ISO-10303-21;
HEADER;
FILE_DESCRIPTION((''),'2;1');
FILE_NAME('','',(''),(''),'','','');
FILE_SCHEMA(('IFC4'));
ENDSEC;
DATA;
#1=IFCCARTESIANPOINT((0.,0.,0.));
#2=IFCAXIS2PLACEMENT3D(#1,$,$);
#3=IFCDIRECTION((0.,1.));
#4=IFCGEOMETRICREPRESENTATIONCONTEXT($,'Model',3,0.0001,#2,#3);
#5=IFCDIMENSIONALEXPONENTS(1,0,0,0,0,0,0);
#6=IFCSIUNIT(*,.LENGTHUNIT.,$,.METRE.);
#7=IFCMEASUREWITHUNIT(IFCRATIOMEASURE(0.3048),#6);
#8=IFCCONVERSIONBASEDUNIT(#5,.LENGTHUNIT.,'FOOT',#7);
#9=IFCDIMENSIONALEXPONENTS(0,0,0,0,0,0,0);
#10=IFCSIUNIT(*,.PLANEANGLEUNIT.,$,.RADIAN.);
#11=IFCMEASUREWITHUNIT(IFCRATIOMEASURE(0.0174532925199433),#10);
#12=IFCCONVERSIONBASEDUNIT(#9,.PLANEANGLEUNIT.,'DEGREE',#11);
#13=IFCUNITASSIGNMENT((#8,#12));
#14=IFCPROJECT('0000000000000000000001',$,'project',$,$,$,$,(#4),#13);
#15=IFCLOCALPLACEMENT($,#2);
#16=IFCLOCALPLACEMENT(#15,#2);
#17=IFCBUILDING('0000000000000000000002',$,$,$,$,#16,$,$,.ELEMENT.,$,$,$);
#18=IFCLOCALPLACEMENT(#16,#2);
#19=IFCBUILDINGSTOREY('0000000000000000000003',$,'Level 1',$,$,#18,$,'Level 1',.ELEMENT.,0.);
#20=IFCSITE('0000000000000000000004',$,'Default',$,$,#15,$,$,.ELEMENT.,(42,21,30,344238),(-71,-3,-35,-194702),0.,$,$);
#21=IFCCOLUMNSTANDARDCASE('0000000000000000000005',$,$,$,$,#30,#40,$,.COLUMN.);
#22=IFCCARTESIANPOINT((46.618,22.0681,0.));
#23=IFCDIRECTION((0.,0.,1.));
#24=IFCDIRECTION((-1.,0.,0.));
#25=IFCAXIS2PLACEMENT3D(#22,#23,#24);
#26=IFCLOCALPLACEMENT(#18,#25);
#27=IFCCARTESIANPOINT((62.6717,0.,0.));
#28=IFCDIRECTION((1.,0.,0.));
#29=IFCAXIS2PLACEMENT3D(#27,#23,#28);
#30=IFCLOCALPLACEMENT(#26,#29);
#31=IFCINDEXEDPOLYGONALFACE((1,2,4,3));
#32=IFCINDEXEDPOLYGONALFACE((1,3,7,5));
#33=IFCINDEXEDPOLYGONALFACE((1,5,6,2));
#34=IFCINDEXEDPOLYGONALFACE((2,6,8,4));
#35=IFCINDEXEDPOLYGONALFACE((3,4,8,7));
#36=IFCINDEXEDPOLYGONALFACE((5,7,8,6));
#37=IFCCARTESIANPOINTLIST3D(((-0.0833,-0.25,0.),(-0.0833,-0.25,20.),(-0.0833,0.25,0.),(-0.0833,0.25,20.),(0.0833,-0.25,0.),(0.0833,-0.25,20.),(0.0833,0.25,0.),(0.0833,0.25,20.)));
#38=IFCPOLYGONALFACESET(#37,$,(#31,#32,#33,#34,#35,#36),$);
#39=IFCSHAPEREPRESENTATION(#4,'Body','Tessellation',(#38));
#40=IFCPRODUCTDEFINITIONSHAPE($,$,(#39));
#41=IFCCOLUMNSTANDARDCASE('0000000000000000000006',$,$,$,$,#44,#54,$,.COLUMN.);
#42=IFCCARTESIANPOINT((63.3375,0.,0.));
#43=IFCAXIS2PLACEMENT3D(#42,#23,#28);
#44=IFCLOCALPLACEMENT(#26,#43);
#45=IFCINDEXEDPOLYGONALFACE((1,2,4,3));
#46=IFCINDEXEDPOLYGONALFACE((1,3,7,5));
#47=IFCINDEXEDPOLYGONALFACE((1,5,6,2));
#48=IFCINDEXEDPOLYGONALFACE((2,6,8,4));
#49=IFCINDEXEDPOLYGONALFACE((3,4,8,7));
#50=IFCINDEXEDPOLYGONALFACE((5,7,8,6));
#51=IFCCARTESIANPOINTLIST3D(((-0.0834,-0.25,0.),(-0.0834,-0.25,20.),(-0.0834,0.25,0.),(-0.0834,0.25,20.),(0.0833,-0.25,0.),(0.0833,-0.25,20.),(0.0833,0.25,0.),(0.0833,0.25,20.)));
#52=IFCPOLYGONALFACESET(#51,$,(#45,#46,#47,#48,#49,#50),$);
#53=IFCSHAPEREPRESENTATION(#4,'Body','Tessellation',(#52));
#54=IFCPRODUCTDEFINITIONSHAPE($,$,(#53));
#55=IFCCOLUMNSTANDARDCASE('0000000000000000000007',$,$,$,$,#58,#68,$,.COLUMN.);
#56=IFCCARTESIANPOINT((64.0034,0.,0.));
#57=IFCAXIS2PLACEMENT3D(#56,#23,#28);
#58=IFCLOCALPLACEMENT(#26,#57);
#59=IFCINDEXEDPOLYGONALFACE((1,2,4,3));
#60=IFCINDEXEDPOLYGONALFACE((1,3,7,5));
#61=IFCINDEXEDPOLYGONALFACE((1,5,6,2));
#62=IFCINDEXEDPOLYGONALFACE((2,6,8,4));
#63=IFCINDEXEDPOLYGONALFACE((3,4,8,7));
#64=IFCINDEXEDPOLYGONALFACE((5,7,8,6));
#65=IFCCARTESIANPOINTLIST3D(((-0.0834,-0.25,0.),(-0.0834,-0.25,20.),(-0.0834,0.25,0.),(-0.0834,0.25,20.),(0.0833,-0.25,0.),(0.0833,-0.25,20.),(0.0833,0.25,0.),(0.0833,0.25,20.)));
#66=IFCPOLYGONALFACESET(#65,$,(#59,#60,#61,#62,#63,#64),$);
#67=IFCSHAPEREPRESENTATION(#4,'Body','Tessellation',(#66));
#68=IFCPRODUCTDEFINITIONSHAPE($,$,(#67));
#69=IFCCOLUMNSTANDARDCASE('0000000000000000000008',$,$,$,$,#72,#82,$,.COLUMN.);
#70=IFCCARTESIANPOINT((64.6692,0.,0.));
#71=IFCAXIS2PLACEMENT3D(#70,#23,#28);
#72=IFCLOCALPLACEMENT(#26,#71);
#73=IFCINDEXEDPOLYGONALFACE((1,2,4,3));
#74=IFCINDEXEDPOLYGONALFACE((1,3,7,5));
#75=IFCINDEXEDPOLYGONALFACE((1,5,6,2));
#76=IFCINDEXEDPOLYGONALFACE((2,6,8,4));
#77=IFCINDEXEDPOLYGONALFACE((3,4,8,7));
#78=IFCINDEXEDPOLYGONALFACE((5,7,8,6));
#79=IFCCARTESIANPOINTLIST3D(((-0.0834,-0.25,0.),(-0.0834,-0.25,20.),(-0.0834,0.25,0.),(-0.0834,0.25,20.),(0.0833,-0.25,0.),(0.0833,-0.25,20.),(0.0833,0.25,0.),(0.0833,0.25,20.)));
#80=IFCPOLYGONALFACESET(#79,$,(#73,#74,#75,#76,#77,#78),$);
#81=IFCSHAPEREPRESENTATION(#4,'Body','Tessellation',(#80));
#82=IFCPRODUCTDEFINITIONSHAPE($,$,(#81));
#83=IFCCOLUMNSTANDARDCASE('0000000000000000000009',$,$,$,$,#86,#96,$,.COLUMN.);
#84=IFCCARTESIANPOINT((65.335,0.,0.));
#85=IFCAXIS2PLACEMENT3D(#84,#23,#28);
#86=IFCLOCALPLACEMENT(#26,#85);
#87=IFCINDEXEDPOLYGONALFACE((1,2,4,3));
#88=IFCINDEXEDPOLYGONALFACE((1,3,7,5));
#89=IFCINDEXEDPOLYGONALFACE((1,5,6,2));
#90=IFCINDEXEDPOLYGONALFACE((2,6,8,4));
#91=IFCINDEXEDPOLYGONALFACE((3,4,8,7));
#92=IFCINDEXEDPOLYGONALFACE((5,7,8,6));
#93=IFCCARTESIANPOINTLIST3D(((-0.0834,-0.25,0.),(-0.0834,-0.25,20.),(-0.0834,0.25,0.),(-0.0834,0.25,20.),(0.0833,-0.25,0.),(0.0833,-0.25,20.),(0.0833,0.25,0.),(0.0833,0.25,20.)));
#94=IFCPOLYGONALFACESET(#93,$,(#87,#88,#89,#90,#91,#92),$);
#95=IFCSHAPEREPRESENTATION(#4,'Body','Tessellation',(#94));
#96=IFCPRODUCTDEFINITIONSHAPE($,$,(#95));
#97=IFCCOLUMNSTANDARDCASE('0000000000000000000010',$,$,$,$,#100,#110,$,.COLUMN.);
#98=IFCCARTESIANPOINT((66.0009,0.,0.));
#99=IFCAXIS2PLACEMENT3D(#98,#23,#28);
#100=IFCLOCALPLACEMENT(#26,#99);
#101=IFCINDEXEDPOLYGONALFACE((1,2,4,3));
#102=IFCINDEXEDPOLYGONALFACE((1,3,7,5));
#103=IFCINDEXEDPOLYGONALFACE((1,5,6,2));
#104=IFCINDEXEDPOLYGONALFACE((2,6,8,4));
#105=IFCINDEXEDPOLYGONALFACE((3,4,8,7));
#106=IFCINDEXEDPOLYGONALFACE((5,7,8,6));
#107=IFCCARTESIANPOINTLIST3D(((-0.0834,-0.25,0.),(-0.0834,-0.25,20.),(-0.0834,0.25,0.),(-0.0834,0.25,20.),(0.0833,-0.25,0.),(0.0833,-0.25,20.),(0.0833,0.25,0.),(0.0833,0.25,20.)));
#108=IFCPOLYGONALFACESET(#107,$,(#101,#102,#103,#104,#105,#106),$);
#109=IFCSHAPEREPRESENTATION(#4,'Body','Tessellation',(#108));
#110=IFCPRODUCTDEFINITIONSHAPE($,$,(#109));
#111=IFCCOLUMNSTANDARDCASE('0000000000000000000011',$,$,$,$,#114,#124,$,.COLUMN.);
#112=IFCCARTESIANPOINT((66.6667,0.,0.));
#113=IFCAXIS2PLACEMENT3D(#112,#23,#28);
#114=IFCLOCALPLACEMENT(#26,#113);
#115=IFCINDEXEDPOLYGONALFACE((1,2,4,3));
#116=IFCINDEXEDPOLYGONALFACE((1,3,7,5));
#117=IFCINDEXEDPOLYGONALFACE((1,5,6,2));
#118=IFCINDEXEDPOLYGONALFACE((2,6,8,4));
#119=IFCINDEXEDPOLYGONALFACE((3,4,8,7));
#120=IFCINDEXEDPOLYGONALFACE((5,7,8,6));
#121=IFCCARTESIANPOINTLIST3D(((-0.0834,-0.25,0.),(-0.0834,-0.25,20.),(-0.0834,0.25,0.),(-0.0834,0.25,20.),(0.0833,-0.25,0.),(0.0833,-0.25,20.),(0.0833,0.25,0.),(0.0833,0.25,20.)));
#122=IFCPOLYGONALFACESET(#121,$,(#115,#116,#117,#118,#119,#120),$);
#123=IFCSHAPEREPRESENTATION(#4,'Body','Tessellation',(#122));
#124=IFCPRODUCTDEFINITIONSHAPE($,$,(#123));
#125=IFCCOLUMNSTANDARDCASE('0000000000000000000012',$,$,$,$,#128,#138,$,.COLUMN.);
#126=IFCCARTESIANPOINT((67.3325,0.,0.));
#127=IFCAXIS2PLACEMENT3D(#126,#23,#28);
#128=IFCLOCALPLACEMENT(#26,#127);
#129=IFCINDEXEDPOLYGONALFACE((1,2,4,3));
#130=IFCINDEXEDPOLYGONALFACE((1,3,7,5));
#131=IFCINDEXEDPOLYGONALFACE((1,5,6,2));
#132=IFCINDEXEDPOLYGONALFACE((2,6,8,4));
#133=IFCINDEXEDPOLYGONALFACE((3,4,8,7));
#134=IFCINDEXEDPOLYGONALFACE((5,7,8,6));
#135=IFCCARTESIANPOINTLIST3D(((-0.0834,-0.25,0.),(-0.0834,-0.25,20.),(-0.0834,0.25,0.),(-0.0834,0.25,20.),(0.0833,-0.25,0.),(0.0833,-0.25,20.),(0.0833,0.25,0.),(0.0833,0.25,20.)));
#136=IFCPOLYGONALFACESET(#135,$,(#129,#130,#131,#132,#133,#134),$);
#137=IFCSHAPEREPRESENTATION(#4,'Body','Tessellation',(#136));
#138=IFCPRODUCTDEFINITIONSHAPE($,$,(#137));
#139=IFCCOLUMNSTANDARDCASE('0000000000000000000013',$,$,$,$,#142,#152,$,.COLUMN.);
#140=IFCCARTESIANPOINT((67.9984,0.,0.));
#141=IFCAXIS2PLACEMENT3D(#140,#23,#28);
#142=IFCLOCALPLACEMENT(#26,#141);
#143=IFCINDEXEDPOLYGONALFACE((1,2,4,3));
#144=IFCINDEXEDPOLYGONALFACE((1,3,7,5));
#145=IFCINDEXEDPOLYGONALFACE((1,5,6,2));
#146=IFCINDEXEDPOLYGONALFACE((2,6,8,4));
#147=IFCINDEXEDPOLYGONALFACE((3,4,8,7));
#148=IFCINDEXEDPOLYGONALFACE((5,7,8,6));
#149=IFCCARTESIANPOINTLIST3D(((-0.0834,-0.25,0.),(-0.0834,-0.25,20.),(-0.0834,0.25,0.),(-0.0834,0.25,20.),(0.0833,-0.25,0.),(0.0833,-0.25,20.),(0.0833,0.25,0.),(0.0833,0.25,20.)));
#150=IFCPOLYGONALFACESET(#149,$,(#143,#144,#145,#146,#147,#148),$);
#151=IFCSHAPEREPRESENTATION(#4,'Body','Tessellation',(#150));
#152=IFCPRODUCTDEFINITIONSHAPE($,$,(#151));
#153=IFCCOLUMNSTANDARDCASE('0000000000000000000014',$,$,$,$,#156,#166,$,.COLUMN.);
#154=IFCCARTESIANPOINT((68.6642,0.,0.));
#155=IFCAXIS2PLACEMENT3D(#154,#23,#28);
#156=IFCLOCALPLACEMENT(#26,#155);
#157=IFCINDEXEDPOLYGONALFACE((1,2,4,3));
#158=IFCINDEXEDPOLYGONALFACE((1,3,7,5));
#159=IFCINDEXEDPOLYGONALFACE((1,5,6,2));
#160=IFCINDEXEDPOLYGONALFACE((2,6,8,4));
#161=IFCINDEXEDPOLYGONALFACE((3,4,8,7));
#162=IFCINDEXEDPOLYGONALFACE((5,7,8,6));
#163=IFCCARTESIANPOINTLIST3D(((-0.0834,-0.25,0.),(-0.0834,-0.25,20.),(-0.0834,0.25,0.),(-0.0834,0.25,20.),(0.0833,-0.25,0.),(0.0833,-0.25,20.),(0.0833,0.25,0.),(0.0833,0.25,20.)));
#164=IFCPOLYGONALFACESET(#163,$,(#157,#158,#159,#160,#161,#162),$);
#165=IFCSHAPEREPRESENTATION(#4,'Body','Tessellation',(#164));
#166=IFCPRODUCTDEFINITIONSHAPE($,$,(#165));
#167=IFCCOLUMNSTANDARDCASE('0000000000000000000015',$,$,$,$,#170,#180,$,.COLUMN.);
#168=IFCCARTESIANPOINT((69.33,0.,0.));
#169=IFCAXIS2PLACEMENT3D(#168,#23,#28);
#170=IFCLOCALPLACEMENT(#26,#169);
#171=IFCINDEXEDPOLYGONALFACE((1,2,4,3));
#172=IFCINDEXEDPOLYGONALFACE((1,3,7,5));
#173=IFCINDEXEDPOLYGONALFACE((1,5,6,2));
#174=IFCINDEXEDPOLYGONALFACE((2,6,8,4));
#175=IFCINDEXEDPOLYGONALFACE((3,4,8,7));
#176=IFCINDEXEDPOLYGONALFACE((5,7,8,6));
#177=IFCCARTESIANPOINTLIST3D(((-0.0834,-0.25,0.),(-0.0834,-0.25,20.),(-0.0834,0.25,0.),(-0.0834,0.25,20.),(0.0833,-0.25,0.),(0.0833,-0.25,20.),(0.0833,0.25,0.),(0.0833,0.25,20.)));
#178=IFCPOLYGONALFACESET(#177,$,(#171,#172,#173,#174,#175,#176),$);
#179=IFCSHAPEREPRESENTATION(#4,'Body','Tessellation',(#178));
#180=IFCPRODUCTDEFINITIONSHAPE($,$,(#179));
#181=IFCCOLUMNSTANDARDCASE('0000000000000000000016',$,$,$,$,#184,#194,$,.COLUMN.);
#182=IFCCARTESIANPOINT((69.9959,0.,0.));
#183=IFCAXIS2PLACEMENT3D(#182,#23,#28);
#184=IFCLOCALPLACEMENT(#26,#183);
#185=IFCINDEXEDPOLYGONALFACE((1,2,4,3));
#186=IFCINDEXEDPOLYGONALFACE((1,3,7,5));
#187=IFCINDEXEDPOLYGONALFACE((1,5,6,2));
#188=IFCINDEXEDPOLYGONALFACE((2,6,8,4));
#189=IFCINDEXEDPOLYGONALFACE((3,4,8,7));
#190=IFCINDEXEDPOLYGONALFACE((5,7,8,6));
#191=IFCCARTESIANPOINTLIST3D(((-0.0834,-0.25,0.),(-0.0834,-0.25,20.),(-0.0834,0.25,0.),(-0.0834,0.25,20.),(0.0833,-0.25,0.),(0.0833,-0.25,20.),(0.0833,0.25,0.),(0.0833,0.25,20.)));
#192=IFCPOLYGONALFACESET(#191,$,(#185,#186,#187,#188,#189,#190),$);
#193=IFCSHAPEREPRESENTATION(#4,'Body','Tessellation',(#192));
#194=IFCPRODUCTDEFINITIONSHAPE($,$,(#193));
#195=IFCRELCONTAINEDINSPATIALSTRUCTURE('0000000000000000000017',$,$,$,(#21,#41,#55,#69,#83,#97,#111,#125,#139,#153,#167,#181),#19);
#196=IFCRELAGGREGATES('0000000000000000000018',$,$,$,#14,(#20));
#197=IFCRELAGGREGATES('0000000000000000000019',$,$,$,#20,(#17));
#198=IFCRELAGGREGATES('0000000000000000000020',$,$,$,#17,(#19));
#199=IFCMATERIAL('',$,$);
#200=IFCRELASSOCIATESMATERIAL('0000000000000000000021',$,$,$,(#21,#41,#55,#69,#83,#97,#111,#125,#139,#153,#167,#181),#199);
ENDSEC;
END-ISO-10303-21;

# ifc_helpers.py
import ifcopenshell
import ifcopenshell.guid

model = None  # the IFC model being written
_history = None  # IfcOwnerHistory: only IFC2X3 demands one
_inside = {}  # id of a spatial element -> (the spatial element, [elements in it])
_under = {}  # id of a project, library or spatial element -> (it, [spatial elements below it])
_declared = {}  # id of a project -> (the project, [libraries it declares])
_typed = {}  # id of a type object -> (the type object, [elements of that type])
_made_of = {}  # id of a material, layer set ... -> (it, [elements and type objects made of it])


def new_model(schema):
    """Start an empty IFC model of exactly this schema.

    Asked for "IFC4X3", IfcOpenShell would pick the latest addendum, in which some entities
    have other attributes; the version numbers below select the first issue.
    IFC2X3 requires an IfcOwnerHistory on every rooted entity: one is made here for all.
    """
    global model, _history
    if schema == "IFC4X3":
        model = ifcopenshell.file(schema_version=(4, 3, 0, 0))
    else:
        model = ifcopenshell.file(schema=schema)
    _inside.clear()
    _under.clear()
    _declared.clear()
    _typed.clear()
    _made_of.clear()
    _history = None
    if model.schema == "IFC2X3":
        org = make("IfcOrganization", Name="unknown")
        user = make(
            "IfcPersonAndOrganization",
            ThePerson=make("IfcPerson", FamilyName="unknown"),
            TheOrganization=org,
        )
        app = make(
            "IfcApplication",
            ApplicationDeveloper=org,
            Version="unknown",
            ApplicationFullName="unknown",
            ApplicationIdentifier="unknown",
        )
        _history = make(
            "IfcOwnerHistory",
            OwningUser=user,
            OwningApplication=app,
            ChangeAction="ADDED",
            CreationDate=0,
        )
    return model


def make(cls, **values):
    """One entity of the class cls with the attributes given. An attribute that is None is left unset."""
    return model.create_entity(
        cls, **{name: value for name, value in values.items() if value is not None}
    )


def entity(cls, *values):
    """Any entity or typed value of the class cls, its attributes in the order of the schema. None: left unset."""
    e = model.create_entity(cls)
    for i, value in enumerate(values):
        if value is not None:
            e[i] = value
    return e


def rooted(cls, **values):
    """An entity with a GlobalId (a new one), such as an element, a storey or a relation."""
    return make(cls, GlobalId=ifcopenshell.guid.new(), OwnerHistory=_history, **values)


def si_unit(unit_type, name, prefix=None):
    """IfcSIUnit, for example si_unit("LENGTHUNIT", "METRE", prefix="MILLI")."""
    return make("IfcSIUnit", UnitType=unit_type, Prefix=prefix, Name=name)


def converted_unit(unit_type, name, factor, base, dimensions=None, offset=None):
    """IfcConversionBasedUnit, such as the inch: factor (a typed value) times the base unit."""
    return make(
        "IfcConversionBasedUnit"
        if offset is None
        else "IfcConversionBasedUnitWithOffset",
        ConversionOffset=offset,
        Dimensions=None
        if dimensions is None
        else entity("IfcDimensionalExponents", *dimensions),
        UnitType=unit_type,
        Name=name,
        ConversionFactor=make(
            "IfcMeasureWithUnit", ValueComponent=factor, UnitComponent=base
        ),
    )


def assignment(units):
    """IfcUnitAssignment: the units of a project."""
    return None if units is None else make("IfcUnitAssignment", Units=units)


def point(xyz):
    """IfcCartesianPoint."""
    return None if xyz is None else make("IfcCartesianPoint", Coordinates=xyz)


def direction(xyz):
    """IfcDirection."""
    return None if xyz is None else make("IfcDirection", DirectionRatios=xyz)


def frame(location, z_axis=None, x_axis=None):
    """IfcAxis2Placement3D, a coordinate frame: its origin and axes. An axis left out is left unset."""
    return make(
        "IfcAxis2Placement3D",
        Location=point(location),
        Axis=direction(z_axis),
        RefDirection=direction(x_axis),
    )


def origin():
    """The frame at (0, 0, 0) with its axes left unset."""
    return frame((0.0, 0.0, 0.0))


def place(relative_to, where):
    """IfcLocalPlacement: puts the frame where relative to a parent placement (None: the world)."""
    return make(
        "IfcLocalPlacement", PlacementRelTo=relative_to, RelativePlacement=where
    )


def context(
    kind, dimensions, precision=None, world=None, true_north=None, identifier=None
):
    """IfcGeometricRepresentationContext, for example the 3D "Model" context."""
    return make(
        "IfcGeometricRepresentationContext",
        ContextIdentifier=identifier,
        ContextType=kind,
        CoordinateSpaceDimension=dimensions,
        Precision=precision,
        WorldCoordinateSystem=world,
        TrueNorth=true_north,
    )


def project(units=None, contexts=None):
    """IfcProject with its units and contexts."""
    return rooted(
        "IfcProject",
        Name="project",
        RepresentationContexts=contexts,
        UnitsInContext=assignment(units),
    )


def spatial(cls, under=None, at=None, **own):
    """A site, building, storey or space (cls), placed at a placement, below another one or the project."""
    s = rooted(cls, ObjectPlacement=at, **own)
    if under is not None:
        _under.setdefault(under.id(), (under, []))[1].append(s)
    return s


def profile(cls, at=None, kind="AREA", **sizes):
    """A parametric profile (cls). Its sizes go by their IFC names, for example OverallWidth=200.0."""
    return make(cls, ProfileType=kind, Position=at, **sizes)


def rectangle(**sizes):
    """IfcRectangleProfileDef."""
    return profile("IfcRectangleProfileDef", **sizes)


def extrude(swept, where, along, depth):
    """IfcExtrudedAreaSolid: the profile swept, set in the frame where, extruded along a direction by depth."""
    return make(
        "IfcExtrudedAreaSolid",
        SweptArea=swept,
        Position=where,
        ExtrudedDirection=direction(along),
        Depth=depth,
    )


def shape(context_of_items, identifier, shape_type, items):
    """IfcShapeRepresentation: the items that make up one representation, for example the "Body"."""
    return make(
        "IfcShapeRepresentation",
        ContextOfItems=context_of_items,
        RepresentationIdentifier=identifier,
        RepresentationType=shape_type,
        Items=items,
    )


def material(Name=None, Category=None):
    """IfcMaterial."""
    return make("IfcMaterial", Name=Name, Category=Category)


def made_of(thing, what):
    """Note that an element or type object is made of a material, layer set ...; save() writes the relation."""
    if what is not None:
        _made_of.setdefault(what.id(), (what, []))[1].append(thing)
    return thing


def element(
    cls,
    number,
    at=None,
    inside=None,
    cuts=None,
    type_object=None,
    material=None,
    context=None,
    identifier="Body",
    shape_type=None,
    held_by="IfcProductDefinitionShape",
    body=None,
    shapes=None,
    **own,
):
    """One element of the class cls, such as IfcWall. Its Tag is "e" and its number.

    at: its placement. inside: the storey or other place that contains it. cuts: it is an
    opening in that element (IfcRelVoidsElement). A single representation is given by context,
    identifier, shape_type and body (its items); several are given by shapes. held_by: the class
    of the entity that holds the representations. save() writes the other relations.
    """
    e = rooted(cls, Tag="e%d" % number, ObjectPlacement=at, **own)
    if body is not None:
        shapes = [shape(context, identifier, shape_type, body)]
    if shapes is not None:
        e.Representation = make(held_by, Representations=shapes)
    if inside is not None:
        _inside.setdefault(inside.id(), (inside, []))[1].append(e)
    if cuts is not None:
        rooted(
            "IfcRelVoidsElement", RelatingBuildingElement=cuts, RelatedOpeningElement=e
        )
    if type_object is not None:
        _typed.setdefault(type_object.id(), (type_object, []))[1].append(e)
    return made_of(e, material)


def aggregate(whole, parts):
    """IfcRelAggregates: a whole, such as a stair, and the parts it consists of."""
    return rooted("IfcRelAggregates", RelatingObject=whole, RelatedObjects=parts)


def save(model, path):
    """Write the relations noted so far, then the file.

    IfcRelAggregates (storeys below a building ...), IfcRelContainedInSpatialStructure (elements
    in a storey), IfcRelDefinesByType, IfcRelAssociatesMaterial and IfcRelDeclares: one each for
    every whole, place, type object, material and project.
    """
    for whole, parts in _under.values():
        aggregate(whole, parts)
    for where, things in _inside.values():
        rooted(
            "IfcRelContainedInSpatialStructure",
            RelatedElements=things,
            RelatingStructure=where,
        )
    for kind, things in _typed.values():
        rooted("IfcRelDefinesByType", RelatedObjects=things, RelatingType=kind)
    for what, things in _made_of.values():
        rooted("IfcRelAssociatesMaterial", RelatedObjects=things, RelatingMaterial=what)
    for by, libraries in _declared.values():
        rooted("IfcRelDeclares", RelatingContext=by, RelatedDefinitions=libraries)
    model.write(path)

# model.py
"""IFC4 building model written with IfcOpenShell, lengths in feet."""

from ifc_helpers import new_model, entity, si_unit, converted_unit, direction, frame, origin, place, context, project, spatial, rectangle, extrude, material, element, save


model = new_model("IFC4")

# Units and contexts
model_context = context("Model", 3, precision=0.0001, world=origin(), true_north=direction((0.0, 1.0)))
ifc_project = project(units=[converted_unit("LENGTHUNIT", "FOOT", entity("IfcRatioMeasure", 0.3048), si_unit("LENGTHUNIT", "METRE"), dimensions=[1, 0, 0, 0, 0, 0, 0]), converted_unit("PLANEANGLEUNIT", "DEGREE", entity("IfcRatioMeasure", 0.0174532925199433), si_unit("PLANEANGLEUNIT", "RADIAN"), dimensions=[0, 0, 0, 0, 0, 0, 0])], contexts=[model_context])

# Site, building, storey
site_placement = place(None, origin())
site = spatial("IfcSite", under=ifc_project, at=site_placement, Name="Default", CompositionType="ELEMENT", RefLatitude=(42, 21, 30, 344238), RefLongitude=(-71, -3, -35, -194702), RefElevation=0.0)
building_placement = place(site_placement, origin())
building = spatial("IfcBuilding", under=site, at=building_placement, CompositionType="ELEMENT")
storey_placement = place(building_placement, origin())
storey = spatial("IfcBuildingStorey", under=building, at=storey_placement, Name="Level 1", LongName="Level 1", CompositionType="ELEMENT", Elevation=0.0)

# Columns
ifc_material_1 = material(Name="")
placement = place(storey_placement, frame((46.618, 22.0681, 0.0), z_axis=(0.0, 0.0, 1.0), x_axis=(-1.0, 0.0, 0.0)))
for number, where, z_axis, x_axis in (
    (1, (62.6717, 0.0, 0.0), (0.0, 0.0, 1.0), (1.0, 0.0, 0.0)),
    (2, (63.3375, 0.0, 0.0), (0.0, 0.0, 1.0), (1.0, 0.0, 0.0)),
    (3, (64.0034, 0.0, 0.0), (0.0, 0.0, 1.0), (1.0, 0.0, 0.0)),
    (4, (64.6692, 0.0, 0.0), (0.0, 0.0, 1.0), (1.0, 0.0, 0.0)),
    (5, (65.335, 0.0, 0.0), (0.0, 0.0, 1.0), (1.0, 0.0, 0.0)),
    (6, (66.0009, 0.0, 0.0), (0.0, 0.0, 1.0), (1.0, 0.0, 0.0)),
    (7, (66.6667, 0.0, 0.0), (0.0, 0.0, 1.0), (1.0, 0.0, 0.0)),
    (8, (67.3325, 0.0, 0.0), (0.0, 0.0, 1.0), (1.0, 0.0, 0.0)),
    (9, (67.9984, 0.0, 0.0), (0.0, 0.0, 1.0), (1.0, 0.0, 0.0)),
    (10, (68.6642, 0.0, 0.0), (0.0, 0.0, 1.0), (1.0, 0.0, 0.0)),
    (11, (69.33, 0.0, 0.0), (0.0, 0.0, 1.0), (1.0, 0.0, 0.0)),
    (12, (69.9959, 0.0, 0.0), (0.0, 0.0, 1.0), (1.0, 0.0, 0.0)),
):
    element("IfcColumnStandardCase", number, at=place(placement, frame(where, z_axis=z_axis, x_axis=x_axis)), inside=storey, material=ifc_material_1, PredefinedType="COLUMN", context=model_context, shape_type="SweptSolid", body=[
        extrude(rectangle(XDim=0.1667, YDim=0.5), origin(), (0.0, 0.0, 1.0), 20.0),
    ])

save(model, "model.ifc")
